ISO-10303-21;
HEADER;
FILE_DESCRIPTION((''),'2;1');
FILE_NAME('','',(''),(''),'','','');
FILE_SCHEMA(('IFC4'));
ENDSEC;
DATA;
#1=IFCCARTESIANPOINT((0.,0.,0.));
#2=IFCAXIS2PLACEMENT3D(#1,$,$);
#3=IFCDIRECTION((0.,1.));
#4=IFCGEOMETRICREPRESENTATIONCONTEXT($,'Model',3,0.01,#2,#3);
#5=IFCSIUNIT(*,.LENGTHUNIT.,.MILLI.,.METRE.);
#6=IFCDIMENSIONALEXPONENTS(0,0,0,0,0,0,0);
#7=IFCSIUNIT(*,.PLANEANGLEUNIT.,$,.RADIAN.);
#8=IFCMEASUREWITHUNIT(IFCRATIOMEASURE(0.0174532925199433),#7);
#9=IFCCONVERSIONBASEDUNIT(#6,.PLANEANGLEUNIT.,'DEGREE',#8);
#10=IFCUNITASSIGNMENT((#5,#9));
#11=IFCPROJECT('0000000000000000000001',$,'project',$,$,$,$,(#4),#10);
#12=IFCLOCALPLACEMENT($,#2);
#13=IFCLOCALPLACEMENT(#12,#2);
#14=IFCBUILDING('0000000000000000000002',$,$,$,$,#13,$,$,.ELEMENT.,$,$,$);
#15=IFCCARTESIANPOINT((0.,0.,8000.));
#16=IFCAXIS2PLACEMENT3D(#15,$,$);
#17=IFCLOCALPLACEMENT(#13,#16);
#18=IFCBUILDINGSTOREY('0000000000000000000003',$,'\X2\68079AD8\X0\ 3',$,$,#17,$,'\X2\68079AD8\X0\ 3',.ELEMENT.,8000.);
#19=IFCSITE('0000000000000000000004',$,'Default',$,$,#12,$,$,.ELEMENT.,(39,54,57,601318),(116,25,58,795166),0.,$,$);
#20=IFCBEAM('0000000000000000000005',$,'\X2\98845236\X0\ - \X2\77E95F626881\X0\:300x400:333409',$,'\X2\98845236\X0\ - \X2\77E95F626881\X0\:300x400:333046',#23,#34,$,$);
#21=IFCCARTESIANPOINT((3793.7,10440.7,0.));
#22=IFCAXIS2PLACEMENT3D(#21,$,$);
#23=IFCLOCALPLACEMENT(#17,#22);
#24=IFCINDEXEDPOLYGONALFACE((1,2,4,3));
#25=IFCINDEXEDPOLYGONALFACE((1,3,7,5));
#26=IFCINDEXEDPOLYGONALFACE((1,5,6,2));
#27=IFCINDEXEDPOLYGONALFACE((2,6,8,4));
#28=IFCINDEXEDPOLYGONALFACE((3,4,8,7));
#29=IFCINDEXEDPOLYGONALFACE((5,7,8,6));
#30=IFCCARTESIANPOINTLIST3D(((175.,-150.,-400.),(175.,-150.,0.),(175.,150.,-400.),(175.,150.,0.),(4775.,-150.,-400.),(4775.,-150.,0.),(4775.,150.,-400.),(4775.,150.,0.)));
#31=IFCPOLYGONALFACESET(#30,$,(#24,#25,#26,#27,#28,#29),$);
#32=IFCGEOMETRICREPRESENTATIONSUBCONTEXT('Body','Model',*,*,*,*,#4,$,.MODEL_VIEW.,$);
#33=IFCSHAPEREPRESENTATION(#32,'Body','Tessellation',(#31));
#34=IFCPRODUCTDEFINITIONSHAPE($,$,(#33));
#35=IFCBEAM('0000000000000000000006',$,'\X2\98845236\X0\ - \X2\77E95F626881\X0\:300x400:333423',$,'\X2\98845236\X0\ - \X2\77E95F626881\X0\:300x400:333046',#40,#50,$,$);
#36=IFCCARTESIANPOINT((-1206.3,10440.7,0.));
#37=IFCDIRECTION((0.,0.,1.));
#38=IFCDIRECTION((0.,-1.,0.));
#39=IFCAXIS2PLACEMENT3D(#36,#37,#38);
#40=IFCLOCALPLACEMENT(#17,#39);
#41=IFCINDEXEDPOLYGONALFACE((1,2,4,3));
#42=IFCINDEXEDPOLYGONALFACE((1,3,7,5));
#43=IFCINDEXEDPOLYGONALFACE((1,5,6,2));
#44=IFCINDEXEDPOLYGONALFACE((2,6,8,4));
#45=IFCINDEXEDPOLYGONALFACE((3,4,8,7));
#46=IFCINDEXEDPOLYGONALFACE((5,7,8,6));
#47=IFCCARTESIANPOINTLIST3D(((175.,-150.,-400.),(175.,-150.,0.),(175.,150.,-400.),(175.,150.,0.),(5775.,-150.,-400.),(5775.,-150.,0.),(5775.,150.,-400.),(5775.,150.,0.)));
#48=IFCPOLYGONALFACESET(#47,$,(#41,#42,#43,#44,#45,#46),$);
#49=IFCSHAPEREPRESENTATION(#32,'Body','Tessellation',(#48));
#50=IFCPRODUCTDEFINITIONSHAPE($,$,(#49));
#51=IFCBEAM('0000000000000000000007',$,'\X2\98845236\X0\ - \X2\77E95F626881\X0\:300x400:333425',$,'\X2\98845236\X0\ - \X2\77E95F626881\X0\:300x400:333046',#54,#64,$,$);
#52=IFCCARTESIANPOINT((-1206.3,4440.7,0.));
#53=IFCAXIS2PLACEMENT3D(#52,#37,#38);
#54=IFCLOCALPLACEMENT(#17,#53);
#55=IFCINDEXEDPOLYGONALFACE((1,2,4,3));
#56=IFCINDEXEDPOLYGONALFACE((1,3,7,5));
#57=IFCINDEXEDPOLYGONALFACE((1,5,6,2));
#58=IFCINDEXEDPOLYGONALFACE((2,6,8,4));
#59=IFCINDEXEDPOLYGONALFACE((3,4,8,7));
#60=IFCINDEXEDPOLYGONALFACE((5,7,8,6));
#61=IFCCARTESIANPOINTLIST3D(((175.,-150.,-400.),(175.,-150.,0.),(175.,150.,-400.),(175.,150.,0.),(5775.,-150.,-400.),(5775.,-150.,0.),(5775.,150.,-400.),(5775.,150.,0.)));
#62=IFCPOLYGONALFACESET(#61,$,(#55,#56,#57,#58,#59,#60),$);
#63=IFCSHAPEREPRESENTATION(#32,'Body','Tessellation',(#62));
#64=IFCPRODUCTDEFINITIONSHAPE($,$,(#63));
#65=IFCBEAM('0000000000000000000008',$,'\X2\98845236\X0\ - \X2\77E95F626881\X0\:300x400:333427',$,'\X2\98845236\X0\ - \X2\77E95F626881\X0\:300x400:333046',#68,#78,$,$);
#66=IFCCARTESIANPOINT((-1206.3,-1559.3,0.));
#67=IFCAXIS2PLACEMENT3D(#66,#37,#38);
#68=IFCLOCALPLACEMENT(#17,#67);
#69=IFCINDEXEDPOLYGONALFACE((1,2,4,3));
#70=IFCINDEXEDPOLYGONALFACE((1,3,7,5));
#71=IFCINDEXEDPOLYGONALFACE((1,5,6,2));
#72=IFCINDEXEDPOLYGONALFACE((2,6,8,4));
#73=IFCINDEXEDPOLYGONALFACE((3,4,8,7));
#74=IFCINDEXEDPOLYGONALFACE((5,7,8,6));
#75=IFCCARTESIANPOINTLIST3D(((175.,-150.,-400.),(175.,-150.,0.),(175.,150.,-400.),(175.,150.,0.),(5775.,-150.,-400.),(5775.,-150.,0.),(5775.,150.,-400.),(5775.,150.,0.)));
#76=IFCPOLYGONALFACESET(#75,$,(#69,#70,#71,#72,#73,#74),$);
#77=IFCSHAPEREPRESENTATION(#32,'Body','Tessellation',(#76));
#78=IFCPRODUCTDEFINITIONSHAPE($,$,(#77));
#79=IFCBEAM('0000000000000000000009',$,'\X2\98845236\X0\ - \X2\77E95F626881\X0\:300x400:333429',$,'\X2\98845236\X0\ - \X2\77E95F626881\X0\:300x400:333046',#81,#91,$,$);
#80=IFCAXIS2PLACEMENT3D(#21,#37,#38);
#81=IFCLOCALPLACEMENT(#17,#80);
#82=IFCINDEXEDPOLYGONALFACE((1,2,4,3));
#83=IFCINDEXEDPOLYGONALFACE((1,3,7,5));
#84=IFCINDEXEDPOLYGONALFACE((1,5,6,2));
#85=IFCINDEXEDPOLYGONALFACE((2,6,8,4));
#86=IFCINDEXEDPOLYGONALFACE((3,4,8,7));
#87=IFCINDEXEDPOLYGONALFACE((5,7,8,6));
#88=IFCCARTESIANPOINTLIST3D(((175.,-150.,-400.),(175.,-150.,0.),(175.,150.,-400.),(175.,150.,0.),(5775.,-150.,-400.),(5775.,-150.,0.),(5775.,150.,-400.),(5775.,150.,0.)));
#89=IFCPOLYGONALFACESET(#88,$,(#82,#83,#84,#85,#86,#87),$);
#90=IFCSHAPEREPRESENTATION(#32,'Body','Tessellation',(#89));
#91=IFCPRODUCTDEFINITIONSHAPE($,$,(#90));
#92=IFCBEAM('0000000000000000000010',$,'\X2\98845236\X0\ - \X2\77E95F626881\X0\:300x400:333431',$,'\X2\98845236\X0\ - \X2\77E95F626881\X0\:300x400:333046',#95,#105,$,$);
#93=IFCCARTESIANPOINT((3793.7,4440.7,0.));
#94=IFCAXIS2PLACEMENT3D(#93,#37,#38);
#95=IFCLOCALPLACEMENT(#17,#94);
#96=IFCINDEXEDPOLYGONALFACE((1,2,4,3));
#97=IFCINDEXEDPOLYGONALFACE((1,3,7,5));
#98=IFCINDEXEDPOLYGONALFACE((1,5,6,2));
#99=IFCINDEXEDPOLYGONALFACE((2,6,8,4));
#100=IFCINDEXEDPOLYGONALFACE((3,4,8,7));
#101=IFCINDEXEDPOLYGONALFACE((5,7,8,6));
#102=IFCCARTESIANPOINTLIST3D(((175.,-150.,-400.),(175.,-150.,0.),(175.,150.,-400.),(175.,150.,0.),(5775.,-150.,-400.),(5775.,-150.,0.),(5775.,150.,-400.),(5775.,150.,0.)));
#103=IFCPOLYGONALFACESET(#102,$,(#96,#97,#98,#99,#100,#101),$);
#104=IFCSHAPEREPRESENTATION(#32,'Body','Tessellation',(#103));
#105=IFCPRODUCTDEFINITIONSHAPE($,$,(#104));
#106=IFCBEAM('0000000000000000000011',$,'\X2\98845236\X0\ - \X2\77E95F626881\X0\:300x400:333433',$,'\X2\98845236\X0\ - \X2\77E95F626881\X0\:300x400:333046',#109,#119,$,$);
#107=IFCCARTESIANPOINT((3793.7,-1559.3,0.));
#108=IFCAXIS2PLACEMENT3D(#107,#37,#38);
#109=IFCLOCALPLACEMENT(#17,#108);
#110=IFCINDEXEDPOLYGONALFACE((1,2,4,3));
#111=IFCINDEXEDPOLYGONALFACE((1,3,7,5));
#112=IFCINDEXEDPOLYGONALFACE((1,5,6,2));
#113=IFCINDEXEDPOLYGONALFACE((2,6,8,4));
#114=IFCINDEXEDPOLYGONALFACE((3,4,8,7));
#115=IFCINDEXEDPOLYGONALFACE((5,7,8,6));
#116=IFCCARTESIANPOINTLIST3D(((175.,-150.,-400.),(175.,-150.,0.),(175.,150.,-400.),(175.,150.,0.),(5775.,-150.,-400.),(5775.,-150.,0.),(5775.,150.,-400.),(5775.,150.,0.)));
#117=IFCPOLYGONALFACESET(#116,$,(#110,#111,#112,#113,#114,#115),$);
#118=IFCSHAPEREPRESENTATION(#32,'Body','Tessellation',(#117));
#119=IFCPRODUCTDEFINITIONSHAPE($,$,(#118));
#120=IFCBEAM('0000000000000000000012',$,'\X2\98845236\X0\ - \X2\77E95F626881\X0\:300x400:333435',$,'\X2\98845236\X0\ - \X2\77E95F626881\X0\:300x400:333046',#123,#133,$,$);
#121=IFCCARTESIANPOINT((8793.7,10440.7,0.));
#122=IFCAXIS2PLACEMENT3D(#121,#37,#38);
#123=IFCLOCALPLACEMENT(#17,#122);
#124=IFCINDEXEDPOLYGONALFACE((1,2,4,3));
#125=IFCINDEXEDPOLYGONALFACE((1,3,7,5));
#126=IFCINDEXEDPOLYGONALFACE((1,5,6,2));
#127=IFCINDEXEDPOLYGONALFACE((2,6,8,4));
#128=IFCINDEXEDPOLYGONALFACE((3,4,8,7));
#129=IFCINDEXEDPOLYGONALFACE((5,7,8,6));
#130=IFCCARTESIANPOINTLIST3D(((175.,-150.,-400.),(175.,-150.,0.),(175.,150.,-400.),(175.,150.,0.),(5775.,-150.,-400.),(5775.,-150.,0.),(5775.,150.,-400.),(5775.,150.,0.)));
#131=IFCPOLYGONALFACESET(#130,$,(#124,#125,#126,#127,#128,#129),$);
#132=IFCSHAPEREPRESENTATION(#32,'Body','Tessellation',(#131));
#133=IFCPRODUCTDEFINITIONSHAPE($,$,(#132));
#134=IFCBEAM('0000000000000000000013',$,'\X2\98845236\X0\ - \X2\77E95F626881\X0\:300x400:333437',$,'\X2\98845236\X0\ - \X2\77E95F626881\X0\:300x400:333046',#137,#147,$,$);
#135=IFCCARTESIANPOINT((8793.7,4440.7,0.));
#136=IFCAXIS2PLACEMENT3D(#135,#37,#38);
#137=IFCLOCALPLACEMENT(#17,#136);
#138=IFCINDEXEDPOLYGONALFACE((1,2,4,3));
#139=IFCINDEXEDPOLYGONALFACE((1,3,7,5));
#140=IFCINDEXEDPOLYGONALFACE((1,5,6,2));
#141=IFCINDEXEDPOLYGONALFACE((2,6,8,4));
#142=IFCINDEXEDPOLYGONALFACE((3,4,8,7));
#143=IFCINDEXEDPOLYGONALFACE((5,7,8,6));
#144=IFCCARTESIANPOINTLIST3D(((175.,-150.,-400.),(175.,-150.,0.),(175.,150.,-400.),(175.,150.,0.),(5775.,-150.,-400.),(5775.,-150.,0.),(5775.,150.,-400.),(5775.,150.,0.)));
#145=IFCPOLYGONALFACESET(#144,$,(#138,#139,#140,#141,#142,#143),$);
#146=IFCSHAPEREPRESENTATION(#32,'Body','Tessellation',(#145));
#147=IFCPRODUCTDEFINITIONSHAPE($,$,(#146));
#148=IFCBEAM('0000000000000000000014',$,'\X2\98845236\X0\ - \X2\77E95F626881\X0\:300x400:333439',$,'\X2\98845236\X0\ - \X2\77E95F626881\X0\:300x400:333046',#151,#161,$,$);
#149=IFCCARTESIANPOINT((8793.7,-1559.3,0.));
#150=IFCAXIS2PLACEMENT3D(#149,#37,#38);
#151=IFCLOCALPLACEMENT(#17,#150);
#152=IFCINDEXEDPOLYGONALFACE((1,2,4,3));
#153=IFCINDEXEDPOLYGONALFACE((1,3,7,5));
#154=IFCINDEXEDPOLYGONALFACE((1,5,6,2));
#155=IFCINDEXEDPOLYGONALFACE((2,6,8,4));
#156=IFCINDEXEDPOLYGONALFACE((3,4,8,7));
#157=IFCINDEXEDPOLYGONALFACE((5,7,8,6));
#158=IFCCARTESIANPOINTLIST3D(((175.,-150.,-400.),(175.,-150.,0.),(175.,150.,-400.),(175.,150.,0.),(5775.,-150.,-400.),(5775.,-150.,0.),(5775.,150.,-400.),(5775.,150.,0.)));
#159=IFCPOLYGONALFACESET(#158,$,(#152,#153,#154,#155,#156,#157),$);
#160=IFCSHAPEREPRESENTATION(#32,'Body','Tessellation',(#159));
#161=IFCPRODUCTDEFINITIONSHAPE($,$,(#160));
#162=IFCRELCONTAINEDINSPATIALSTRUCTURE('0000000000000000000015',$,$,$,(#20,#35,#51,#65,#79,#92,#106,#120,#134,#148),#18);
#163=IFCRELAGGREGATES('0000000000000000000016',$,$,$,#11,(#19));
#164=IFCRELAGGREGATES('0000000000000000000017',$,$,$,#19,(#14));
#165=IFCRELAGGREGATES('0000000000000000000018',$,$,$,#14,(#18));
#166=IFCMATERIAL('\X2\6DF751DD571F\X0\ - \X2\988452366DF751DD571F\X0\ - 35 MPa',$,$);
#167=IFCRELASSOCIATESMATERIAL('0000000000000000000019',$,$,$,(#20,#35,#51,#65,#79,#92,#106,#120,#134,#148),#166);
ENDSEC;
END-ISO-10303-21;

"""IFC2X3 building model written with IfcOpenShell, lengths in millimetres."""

from ifc_helpers import new_model, entity, si_unit, converted_unit, direction, frame, frame_2d, origin, origin_2d_with_axis, place, context, subcontext, project, spatial, rectangle, extrude, material, element, save


model = new_model("IFC2X3")

# Units and contexts
model_context = context("Model", 3, precision=0.01, world=origin(), true_north=direction((0.0, 1.0)))
body_context = subcontext(model_context, "Body", "Model", "MODEL_VIEW")
ifc_project = project(units=[si_unit("LENGTHUNIT", "METRE", prefix="MILLI"), converted_unit("PLANEANGLEUNIT", "DEGREE", entity("IfcRatioMeasure", 0.0174532925199433), si_unit("PLANEANGLEUNIT", "RADIAN"), dimensions=[0, 0, 0, 0, 0, 0, 0])], contexts=[model_context])

# Site, building, storey
site_placement = place(None, origin())
site = spatial("IfcSite", under=ifc_project, at=site_placement, Name="Default", CompositionType="ELEMENT", RefLatitude=(39, 54, 57, 601318), RefLongitude=(116, 25, 58, 795166), RefElevation=0.0)
building_placement = place(site_placement, origin())
building = spatial("IfcBuilding", under=site, at=building_placement, CompositionType="ELEMENT")
storey_placement = place(building_placement, frame((0.0, 0.0, 8000.0)))
storey = spatial("IfcBuildingStorey", under=building, at=storey_placement, Name="标高 3", LongName="标高 3", CompositionType="ELEMENT", Elevation=8000.0)

# Shared definitions
ifc_material_1 = material(Name="混凝土 - 预制混凝土 - 35 MPa")

# Beams
beam_1_placement = place(storey_placement, frame((3793.7, 10440.7, 0.0)))
element("IfcBeam", 1, at=beam_1_placement, inside=storey, material=ifc_material_1, Name="预制 - 矩形梁:300x400:333409", ObjectType="预制 - 矩形梁:300x400:333046", context=body_context, shape_type="SweptSolid", body=[
    extrude(rectangle(XDim=400.0, YDim=300.0, at=frame_2d((0.0, 0.0), x_axis=(1.0, 0.0))), frame((175.0, 0.0, -200.0), z_axis=(1.0, 0.0, 0.0), x_axis=(0.0, 0.0, -1.0)), (0.0, 0.0, 1.0), 4600.0),
])
beam_2_placement = place(storey_placement, frame((-1206.3, 10440.7, 0.0), z_axis=(0.0, 0.0, 1.0), x_axis=(0.0, -1.0, 0.0)))
element("IfcBeam", 2, at=beam_2_placement, inside=storey, material=ifc_material_1, Name="预制 - 矩形梁:300x400:333423", ObjectType="预制 - 矩形梁:300x400:333046", context=body_context, shape_type="SweptSolid", body=[
    extrude(rectangle(XDim=400.0, YDim=300.0, at=frame_2d((0.0, 0.0), x_axis=(1.0, 0.0))), frame((175.0, 0.0, -200.0), z_axis=(1.0, 0.0, 0.0), x_axis=(0.0, 0.0, -1.0)), (0.0, 0.0, 1.0), 5600.0),
])
beam_3_placement = place(storey_placement, frame((-1206.3, 4440.7, 0.0), z_axis=(0.0, 0.0, 1.0), x_axis=(0.0, -1.0, 0.0)))
element("IfcBeam", 3, at=beam_3_placement, inside=storey, material=ifc_material_1, Name="预制 - 矩形梁:300x400:333425", ObjectType="预制 - 矩形梁:300x400:333046", context=body_context, shape_type="SweptSolid", body=[
    extrude(rectangle(XDim=400.0, YDim=300.0, at=frame_2d((0.0, 0.0), x_axis=(1.0, 0.0))), frame((175.0, 0.0, -200.0), z_axis=(1.0, 0.0, 0.0), x_axis=(0.0, 0.0, -1.0)), (0.0, 0.0, 1.0), 5600.0),
])
beam_4_placement = place(storey_placement, frame((-1206.3, -1559.3, 0.0), z_axis=(0.0, 0.0, 1.0), x_axis=(0.0, -1.0, 0.0)))
element("IfcBeam", 4, at=beam_4_placement, inside=storey, material=ifc_material_1, Name="预制 - 矩形梁:300x400:333427", ObjectType="预制 - 矩形梁:300x400:333046", context=body_context, shape_type="SweptSolid", body=[
    extrude(rectangle(XDim=400.0, YDim=300.0, at=frame_2d((0.0, 0.0), x_axis=(1.0, 0.0))), frame((175.0, 0.0, -200.0), z_axis=(1.0, 0.0, 0.0), x_axis=(0.0, 0.0, -1.0)), (0.0, 0.0, 1.0), 5600.0),
])
beam_5_placement = place(storey_placement, frame((3793.7, 10440.7, 0.0), z_axis=(0.0, 0.0, 1.0), x_axis=(0.0, -1.0, 0.0)))
element("IfcBeam", 5, at=beam_5_placement, inside=storey, material=ifc_material_1, Name="预制 - 矩形梁:300x400:333429", ObjectType="预制 - 矩形梁:300x400:333046", context=body_context, shape_type="SweptSolid", body=[
    extrude(rectangle(XDim=400.0, YDim=300.0, at=frame_2d((0.0, 0.0), x_axis=(1.0, 0.0))), frame((175.0, 0.0, -200.0), z_axis=(1.0, 0.0, 0.0), x_axis=(0.0, 0.0, -1.0)), (0.0, 0.0, 1.0), 5600.0),
])
beam_6_placement = place(storey_placement, frame((3793.7, 4440.7, 0.0), z_axis=(0.0, 0.0, 1.0), x_axis=(0.0, -1.0, 0.0)))
element("IfcBeam", 6, at=beam_6_placement, inside=storey, material=ifc_material_1, Name="预制 - 矩形梁:300x400:333431", ObjectType="预制 - 矩形梁:300x400:333046", context=body_context, shape_type="SweptSolid", body=[
    extrude(rectangle(XDim=400.0, YDim=300.0, at=origin_2d_with_axis()), frame((175.0, 0.0, -200.0), z_axis=(1.0, 0.0, 0.0), x_axis=(0.0, 0.0, -1.0)), (0.0, 0.0, 1.0), 5600.0),
])
beam_7_placement = place(storey_placement, frame((3793.7, -1559.3, 0.0), z_axis=(0.0, 0.0, 1.0), x_axis=(0.0, -1.0, 0.0)))
element("IfcBeam", 7, at=beam_7_placement, inside=storey, material=ifc_material_1, Name="预制 - 矩形梁:300x400:333433", ObjectType="预制 - 矩形梁:300x400:333046", context=body_context, shape_type="SweptSolid", body=[
    extrude(rectangle(XDim=400.0, YDim=300.0, at=frame_2d((0.0, 0.0), x_axis=(1.0, 0.0))), frame((175.0, 0.0, -200.0), z_axis=(1.0, 0.0, 0.0), x_axis=(0.0, 0.0, -1.0)), (0.0, 0.0, 1.0), 5600.0),
])
for number, where, z_axis, x_axis, name in (
    (8, (8793.7, 10440.7, 0.0), (0.0, 0.0, 1.0), (0.0, -1.0, 0.0), "预制 - 矩形梁:300x400:333435"),
    (9, (8793.7, 4440.7, 0.0), (0.0, 0.0, 1.0), (0.0, -1.0, 0.0), "预制 - 矩形梁:300x400:333437"),
    (10, (8793.7, -1559.3, 0.0), (0.0, 0.0, 1.0), (0.0, -1.0, 0.0), "预制 - 矩形梁:300x400:333439"),
):
    element("IfcBeam", number, at=place(storey_placement, frame(where, z_axis=z_axis, x_axis=x_axis)), inside=storey, material=ifc_material_1, Name=name, ObjectType="预制 - 矩形梁:300x400:333046", context=body_context, shape_type="SweptSolid", body=[
        extrude(rectangle(XDim=400.0, YDim=300.0, at=origin_2d_with_axis()), frame((175.0, 0.0, -200.0), z_axis=(1.0, 0.0, 0.0), x_axis=(0.0, 0.0, -1.0)), (0.0, 0.0, 1.0), 5600.0),
    ])

save(model, "model.ifc")
